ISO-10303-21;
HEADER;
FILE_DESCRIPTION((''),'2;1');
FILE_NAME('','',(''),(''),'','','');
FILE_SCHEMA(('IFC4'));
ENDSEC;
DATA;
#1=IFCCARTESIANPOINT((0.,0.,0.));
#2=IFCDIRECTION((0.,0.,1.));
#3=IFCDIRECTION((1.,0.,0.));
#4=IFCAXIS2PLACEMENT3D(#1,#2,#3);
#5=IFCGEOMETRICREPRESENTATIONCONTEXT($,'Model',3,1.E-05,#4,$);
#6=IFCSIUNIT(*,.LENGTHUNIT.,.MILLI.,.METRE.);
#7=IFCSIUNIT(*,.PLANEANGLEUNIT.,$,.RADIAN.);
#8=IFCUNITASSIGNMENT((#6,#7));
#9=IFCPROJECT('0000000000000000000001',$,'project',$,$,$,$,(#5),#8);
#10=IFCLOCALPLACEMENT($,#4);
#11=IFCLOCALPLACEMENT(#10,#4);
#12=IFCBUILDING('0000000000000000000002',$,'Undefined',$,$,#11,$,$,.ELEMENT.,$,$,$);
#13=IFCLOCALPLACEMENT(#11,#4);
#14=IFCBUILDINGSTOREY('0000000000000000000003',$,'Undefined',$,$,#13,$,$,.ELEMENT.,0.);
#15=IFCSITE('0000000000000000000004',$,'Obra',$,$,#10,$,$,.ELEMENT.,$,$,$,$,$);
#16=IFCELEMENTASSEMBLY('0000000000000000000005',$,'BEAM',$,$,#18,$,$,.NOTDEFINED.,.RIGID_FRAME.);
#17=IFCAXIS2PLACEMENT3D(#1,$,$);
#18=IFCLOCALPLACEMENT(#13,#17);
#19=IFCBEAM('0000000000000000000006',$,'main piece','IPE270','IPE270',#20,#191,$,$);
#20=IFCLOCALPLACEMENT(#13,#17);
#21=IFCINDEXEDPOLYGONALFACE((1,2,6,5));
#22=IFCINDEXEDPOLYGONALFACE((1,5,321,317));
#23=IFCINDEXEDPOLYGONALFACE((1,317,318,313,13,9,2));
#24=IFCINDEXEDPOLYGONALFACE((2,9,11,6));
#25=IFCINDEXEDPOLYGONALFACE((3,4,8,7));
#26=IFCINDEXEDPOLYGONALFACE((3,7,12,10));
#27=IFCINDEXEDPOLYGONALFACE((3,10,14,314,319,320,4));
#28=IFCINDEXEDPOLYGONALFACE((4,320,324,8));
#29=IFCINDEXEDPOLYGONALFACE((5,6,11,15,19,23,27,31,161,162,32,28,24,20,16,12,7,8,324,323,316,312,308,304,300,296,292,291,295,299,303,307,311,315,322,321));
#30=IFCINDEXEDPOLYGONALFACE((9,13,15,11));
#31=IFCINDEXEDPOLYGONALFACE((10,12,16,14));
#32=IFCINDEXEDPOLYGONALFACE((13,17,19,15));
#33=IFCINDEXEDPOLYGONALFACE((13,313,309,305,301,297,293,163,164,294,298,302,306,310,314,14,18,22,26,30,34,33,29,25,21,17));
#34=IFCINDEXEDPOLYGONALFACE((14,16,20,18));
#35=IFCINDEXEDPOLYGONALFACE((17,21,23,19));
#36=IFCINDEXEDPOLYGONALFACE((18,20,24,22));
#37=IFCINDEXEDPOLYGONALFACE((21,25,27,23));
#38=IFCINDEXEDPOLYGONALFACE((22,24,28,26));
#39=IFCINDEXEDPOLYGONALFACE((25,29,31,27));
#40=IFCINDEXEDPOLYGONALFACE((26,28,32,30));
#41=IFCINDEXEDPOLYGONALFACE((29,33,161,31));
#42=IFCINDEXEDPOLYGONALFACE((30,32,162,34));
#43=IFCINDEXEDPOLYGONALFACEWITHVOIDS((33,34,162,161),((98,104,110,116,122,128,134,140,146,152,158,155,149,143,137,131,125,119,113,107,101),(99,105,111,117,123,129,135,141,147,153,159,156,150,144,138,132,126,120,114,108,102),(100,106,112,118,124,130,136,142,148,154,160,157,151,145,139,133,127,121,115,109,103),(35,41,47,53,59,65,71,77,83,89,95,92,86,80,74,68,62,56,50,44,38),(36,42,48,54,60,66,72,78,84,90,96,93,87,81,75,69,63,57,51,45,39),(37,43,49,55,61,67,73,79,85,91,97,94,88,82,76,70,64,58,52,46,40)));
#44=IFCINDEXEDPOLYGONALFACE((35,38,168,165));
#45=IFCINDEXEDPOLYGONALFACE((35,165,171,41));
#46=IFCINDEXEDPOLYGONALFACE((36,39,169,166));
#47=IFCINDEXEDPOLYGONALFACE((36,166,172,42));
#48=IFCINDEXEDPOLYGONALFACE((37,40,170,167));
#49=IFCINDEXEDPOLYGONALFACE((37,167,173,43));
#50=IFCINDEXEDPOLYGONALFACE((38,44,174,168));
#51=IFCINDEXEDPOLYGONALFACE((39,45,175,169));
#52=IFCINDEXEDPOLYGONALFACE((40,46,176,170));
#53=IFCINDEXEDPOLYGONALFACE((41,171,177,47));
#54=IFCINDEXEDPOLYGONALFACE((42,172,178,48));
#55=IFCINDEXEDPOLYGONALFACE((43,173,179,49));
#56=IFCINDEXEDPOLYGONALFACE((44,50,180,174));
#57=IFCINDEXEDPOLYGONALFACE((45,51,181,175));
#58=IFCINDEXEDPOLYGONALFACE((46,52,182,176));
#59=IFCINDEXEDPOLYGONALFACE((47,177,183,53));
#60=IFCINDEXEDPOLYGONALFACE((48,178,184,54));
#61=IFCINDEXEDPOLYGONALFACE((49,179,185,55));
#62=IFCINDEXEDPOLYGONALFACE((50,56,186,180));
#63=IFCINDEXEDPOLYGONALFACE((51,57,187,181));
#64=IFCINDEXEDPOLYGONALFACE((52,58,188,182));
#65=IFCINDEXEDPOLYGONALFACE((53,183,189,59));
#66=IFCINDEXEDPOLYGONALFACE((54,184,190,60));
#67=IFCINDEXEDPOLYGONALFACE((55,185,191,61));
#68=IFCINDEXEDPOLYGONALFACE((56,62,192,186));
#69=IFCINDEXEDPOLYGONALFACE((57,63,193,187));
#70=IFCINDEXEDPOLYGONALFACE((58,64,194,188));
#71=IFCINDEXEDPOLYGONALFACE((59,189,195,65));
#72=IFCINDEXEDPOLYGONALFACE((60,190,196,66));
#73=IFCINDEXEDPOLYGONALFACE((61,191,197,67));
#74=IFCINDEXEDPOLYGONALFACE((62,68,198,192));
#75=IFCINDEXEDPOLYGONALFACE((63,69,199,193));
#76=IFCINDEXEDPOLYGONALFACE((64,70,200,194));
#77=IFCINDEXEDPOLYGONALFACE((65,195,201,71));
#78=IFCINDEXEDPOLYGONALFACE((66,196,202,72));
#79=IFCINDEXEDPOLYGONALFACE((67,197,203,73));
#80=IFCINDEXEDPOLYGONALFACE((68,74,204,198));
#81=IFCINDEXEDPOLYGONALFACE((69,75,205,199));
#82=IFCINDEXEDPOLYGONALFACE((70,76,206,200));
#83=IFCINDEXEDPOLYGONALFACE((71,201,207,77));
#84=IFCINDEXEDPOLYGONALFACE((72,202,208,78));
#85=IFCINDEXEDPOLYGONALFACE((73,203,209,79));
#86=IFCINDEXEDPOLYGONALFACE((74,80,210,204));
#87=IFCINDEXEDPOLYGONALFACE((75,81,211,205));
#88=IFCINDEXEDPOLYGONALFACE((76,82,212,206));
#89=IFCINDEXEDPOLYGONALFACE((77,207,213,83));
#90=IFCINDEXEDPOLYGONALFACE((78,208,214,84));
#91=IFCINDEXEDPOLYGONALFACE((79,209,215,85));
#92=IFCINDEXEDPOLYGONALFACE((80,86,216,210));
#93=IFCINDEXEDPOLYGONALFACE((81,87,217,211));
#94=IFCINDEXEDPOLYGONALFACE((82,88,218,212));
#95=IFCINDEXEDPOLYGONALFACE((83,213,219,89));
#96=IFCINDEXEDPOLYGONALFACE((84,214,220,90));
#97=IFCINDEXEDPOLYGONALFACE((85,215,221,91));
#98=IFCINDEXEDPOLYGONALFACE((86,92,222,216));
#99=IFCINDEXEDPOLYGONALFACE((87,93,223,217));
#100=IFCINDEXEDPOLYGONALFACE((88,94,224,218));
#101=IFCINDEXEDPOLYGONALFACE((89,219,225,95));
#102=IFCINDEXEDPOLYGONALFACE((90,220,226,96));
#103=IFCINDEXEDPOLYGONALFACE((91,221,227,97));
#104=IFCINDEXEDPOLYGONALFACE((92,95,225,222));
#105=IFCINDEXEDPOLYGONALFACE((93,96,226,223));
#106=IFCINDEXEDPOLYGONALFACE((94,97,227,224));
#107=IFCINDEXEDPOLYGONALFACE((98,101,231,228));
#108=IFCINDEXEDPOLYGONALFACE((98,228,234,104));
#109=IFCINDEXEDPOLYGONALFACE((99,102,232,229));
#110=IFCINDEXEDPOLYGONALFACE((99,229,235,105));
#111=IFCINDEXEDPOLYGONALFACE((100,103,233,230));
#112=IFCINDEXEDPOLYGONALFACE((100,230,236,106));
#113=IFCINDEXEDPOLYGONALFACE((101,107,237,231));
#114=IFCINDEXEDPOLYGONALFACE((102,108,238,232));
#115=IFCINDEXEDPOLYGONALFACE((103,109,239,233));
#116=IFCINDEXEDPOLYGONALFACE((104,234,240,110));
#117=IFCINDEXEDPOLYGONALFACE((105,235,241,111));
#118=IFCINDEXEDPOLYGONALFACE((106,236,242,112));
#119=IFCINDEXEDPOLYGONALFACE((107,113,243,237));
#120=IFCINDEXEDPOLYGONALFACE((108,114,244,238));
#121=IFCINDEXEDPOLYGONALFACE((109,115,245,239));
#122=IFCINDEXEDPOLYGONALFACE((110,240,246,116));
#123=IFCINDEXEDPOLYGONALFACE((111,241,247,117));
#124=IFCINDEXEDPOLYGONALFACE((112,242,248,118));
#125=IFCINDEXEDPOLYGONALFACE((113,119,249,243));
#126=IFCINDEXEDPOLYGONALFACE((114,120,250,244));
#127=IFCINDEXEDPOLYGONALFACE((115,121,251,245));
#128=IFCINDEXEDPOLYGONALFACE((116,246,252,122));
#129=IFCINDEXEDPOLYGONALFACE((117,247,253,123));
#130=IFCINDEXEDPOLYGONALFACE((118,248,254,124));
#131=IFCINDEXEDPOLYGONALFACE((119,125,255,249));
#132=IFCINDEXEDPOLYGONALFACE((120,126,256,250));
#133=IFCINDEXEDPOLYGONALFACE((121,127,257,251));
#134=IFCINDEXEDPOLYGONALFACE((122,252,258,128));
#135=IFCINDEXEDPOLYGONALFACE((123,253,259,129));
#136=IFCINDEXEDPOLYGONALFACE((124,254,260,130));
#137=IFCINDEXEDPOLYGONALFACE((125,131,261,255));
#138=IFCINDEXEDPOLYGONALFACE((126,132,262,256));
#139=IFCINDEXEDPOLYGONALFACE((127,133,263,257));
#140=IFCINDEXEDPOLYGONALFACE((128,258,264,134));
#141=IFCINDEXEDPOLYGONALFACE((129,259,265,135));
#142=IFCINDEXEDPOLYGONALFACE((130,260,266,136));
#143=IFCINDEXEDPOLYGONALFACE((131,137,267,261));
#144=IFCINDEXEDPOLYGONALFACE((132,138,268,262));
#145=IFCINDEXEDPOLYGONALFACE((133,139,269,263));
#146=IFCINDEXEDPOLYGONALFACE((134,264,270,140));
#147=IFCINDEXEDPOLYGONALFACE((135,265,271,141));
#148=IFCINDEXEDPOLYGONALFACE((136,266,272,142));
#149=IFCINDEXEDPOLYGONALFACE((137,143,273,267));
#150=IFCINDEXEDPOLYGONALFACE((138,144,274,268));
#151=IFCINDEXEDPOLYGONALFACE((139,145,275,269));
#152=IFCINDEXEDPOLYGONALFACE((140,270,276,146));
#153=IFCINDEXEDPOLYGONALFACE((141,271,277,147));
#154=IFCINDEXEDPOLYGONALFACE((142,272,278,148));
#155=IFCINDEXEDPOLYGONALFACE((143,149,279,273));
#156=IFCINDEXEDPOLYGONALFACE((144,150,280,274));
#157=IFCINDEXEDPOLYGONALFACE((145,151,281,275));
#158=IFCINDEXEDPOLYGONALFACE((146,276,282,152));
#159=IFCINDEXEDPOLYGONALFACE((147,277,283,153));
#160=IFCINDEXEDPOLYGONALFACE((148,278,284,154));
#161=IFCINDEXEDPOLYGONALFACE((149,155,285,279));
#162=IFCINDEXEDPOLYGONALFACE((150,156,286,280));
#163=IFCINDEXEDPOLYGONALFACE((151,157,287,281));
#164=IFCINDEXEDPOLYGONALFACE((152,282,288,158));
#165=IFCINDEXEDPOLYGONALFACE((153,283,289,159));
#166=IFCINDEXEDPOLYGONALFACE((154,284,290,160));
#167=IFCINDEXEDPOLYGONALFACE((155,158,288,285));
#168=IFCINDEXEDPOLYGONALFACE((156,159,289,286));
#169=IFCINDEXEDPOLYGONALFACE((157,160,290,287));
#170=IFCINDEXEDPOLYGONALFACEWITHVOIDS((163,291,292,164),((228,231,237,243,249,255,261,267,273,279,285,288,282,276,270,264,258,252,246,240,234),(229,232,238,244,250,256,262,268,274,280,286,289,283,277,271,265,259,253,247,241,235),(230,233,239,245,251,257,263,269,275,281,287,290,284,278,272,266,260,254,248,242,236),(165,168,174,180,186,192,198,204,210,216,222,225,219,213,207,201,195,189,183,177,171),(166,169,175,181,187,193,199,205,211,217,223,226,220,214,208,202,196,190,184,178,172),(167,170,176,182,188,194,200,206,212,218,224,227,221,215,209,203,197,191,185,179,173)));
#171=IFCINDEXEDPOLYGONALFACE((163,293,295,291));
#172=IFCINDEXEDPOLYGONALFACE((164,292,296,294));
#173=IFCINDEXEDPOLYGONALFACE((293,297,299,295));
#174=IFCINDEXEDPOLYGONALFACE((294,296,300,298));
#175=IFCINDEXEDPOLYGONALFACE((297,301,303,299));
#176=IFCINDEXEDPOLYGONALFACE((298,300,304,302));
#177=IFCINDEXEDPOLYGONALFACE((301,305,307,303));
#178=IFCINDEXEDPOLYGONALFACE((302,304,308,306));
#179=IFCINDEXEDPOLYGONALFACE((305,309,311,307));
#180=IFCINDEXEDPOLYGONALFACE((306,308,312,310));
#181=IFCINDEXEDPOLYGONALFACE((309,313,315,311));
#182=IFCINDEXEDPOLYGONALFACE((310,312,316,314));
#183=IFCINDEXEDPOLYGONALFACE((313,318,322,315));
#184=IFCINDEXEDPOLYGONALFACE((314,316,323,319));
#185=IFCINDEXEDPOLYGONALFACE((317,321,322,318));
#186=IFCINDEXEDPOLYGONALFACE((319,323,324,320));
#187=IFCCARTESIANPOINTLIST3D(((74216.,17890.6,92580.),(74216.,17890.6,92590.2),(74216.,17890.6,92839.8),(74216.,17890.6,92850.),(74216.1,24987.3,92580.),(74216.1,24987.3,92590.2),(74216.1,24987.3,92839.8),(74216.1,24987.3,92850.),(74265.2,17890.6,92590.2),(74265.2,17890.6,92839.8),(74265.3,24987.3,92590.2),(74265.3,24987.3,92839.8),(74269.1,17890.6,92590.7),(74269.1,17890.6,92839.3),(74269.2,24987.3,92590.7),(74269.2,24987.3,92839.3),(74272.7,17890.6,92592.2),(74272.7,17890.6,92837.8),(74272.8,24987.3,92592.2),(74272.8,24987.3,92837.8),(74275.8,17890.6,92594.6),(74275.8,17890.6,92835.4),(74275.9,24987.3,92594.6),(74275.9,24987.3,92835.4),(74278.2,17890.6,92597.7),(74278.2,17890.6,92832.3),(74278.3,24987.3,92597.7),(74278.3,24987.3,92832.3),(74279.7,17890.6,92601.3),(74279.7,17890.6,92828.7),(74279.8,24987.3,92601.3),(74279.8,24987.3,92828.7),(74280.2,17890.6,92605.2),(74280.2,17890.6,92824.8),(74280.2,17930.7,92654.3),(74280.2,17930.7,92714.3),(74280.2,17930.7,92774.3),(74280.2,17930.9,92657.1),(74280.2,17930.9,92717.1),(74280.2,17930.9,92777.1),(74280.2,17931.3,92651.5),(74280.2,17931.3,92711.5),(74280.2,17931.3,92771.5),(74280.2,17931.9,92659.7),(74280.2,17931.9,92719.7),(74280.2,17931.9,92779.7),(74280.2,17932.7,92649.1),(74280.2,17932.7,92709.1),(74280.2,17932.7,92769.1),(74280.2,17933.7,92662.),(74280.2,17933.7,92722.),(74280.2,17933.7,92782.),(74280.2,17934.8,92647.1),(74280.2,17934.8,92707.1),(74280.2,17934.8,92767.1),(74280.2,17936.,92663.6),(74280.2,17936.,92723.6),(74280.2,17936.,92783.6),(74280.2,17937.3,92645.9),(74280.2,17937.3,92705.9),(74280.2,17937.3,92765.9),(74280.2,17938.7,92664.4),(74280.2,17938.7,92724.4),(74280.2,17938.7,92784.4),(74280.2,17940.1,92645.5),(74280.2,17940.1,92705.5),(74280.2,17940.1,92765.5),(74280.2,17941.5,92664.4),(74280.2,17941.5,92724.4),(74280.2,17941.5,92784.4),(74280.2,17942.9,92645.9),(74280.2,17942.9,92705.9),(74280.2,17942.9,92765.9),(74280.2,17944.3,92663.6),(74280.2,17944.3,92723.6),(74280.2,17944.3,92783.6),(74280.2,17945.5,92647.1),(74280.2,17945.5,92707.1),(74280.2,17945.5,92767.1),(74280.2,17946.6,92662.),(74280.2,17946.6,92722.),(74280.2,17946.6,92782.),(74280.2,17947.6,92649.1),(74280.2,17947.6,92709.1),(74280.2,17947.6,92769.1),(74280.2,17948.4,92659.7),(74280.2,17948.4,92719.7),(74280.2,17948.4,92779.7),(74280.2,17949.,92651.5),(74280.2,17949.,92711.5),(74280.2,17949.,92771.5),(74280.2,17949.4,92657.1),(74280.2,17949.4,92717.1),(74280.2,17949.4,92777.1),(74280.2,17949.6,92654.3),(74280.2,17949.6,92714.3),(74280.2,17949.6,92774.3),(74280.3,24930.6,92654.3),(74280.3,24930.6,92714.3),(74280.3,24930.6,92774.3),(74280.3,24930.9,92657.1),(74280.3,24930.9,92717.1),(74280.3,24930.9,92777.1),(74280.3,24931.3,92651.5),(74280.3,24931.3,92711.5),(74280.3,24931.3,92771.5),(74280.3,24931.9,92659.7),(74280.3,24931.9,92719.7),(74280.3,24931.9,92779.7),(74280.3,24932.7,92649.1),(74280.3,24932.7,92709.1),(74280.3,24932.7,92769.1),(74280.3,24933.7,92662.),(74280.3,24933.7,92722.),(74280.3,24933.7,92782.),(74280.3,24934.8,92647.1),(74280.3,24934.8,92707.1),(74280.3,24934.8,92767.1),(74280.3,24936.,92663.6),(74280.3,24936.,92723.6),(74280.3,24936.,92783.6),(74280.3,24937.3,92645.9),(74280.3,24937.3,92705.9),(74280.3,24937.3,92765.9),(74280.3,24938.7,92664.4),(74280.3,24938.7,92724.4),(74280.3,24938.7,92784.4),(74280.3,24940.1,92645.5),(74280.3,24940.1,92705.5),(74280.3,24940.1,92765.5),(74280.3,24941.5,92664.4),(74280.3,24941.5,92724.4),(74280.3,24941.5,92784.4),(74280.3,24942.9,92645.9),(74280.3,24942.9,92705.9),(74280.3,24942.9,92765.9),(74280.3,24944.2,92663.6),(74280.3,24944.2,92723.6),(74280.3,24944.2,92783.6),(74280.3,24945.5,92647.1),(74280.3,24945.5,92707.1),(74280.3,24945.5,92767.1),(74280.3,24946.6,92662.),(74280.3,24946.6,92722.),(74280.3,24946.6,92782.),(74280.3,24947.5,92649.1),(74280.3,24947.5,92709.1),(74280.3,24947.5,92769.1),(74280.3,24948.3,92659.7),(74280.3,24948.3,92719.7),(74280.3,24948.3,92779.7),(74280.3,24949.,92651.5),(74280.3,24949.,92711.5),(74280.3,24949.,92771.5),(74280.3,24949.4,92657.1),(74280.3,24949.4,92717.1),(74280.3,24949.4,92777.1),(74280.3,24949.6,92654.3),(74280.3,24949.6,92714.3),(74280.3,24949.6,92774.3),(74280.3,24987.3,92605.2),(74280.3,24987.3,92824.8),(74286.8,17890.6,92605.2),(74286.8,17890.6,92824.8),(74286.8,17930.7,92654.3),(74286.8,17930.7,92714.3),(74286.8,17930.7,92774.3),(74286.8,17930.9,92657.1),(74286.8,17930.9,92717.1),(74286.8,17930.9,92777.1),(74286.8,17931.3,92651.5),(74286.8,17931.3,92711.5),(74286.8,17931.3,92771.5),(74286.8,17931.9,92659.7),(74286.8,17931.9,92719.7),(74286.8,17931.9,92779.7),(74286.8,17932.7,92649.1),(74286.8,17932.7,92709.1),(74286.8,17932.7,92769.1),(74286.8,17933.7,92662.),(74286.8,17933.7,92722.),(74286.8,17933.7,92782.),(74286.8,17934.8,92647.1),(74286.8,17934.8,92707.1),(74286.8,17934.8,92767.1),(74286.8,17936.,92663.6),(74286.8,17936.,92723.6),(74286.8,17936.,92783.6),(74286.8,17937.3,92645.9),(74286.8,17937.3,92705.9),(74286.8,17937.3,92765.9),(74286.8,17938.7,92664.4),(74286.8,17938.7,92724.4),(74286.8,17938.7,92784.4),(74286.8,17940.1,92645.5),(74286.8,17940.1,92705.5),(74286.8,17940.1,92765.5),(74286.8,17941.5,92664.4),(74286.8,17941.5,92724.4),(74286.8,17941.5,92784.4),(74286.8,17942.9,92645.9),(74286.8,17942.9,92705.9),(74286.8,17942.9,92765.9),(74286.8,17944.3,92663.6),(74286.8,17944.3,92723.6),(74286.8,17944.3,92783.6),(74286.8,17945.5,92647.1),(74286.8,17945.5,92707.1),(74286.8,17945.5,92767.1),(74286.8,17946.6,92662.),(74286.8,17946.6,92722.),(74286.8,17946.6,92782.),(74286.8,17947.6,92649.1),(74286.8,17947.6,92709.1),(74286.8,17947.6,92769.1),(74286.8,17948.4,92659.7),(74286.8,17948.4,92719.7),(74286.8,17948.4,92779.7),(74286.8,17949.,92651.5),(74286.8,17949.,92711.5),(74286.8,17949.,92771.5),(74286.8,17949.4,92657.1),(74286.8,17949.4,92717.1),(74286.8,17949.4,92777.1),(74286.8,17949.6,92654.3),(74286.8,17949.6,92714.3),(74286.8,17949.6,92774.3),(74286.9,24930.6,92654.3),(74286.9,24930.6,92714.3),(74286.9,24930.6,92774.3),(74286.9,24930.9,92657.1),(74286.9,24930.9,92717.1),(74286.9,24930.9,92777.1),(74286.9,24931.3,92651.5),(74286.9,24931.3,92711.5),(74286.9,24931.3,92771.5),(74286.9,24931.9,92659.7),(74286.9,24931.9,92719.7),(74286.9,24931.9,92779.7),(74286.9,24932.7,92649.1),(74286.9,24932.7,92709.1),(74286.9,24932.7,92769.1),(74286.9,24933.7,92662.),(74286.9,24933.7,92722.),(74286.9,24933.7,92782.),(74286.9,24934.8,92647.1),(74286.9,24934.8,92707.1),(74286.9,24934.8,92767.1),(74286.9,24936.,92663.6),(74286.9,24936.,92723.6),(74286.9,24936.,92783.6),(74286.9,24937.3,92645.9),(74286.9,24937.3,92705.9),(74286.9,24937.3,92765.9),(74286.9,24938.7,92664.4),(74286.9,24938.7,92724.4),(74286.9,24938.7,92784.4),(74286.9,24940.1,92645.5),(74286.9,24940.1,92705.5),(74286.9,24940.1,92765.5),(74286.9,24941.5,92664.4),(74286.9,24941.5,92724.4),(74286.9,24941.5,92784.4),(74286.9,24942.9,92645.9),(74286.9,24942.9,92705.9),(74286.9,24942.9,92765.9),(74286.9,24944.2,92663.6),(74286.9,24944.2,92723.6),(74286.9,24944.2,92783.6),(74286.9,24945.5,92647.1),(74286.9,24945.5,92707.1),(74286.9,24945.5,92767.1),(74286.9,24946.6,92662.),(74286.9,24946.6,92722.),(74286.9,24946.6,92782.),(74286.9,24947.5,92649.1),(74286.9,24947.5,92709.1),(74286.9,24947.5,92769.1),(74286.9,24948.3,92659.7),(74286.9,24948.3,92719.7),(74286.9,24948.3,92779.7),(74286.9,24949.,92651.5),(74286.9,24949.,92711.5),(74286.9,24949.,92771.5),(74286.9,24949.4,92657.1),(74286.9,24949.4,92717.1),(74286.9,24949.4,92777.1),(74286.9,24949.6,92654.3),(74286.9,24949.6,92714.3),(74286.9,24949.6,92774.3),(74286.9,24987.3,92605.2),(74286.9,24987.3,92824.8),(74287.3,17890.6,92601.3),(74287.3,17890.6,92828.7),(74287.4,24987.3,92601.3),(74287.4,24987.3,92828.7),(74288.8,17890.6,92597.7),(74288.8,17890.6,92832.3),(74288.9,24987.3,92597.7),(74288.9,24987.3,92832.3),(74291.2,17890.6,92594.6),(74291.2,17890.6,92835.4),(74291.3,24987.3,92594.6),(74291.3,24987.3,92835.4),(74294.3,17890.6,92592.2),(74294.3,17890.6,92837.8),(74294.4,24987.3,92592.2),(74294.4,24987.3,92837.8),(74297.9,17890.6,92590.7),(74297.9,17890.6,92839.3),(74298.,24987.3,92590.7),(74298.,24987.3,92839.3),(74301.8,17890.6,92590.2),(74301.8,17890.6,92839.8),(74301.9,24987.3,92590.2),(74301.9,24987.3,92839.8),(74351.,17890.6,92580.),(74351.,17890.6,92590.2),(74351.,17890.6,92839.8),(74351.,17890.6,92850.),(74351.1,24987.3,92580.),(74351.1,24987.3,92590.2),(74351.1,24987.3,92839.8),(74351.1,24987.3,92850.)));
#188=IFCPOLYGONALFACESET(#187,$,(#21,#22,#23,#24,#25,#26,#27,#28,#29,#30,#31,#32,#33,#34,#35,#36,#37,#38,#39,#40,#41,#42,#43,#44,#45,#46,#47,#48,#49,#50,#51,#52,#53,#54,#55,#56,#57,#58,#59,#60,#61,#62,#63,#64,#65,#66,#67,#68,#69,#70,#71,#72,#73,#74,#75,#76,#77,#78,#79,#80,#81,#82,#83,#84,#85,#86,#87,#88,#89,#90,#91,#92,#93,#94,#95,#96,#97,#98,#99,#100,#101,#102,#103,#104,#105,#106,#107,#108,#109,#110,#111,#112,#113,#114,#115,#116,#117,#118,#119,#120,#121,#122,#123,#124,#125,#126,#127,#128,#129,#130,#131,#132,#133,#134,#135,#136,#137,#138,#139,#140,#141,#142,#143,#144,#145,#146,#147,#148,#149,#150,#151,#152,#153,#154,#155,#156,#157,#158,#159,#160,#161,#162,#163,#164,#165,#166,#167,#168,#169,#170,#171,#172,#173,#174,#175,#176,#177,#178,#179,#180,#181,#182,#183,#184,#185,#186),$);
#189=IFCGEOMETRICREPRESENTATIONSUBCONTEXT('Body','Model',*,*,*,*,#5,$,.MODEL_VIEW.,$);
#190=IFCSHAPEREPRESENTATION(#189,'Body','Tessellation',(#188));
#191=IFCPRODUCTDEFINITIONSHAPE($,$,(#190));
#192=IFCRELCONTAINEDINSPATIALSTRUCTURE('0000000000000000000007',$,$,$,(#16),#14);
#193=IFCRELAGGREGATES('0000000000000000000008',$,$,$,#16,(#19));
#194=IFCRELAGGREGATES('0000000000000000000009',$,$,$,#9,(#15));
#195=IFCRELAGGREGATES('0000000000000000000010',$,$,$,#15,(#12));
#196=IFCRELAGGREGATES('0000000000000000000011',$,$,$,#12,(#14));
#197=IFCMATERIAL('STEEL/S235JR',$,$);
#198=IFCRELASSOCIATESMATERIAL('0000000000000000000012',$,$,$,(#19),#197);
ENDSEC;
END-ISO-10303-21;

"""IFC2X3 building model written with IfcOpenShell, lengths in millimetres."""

from ifc_helpers import new_model, si_unit, frame, origin_with_axes, origin_2d_with_axis, place, context, subcontext, project, spatial, circle, i_section, extrude, clip, halfspace, source, transform, mapped, material, element, aggregate, save


model = new_model("IFC2X3")

# Units and contexts
model_context = context("Model", 3, precision=1e-05, world=origin_with_axes())
body_context = subcontext(model_context, "Body", "Model", "MODEL_VIEW")
ifc_project = project(units=[si_unit("LENGTHUNIT", "METRE", prefix="MILLI"), si_unit("PLANEANGLEUNIT", "RADIAN")], contexts=[model_context])

# Site, building, storey
site_placement = place(None, origin_with_axes())
site = spatial("IfcSite", under=ifc_project, at=site_placement, Name="Obra", CompositionType="ELEMENT")
building_placement = place(site_placement, origin_with_axes())
building = spatial("IfcBuilding", under=site, at=building_placement, Name="Undefined", CompositionType="ELEMENT")
storey_placement = place(building_placement, origin_with_axes())
storey = spatial("IfcBuildingStorey", under=building, at=storey_placement, Name="Undefined", CompositionType="ELEMENT", Elevation=0.0)

# Shared definitions
ifc_material = material(Name="STEEL/S235JR")

# Element assembly, beam, openings
assembly_1_placement = place(storey_placement, origin_with_axes())
assembly_1 = element("IfcElementAssembly", 1, at=assembly_1_placement, inside=storey, Name="BEAM", AssemblyPlace="NOTDEFINED", PredefinedType="RIGID_FRAME")
beam_1_placement = place(assembly_1_placement, frame((74283.5, 17645.3, 92715.0), z_axis=(0.0, 0.0, 1.0), x_axis=(0.000013, 1.0, 0.0)))
beam_1 = element("IfcBeam", 2, at=beam_1_placement, material=ifc_material, Name="main piece", Description="IPE270", ObjectType="IPE270", context=body_context, shape_type="Clipping", body=[
    clip(clip(extrude(i_section(OverallWidth=135.0, OverallDepth=270.0, WebThickness=6.6, FlangeThickness=10.2, FilletRadius=15.0, at=origin_2d_with_axis()), frame((7342.1, 0.0, 0.0), z_axis=(-1.0, 0.0, 0.0), x_axis=(0.0, -1.0, 0.0)), (0.0, 0.0, 1.0), 7342.1), halfspace(frame((7344.4, -60.0, -120.0), z_axis=(1.0, 0.000034, 0.0), x_axis=(0.0, 0.0, 1.0)), False)), halfspace(frame((245.3, 60.0, -120.0), z_axis=(-1.0, -0.000032, 0.0), x_axis=(0.0, 0.0, 1.0)), False)),
])
shared_shape_1 = source(origin_with_axes(), body_context, "Body", "SweptSolid", [
    extrude(circle(Radius=9.5, at=origin_2d_with_axis()), frame((0.0, -3.4, 0.0), z_axis=(0.0, 1.0, 0.0), x_axis=(1.0, 0.0, 0.0)), (0.0, 0.0, 1.0), 6.8),
])
opening_1_placement = place(assembly_1_placement, frame((74283.6, 24990.1, 92835.0), z_axis=(0.000002, -1.0, 0.0), x_axis=(0.0, 0.0, -1.0)))
element("IfcOpeningElement", 3, at=opening_1_placement, cuts=beam_1, ObjectType="Opening", context=body_context, shape_type="MappedRepresentation", body=[
    mapped(shared_shape_1, transform((60.0, 0.0, 50.0))),
    mapped(shared_shape_1, transform((120.0, 0.0, 50.0))),
    mapped(shared_shape_1, transform((180.0, 0.0, 50.0))),
])
shared_shape_2 = source(origin_with_axes(), body_context, "Body", "SweptSolid", [
    extrude(circle(Radius=9.5, at=origin_2d_with_axis()), frame((0.0, -3.4, 0.0), z_axis=(0.0, 1.0, 0.0), x_axis=(1.0, 0.0, 0.0)), (0.0, 0.0, 1.0), 6.8),
])
opening_2_placement = place(assembly_1_placement, frame((74283.5, 17890.1, 92835.0), z_axis=(0.0, 1.0, 0.0), x_axis=(0.0, 0.0, -1.0)))
element("IfcOpeningElement", 4, at=opening_2_placement, cuts=beam_1, ObjectType="Opening", context=body_context, shape_type="MappedRepresentation", body=[
    mapped(shared_shape_2, transform((60.0, 0.0, 50.0))),
    mapped(shared_shape_2, transform((120.0, 0.0, 50.0))),
    mapped(shared_shape_2, transform((180.0, 0.0, 50.0))),
])
aggregate(assembly_1, [beam_1])

save(model, "model.ifc")
